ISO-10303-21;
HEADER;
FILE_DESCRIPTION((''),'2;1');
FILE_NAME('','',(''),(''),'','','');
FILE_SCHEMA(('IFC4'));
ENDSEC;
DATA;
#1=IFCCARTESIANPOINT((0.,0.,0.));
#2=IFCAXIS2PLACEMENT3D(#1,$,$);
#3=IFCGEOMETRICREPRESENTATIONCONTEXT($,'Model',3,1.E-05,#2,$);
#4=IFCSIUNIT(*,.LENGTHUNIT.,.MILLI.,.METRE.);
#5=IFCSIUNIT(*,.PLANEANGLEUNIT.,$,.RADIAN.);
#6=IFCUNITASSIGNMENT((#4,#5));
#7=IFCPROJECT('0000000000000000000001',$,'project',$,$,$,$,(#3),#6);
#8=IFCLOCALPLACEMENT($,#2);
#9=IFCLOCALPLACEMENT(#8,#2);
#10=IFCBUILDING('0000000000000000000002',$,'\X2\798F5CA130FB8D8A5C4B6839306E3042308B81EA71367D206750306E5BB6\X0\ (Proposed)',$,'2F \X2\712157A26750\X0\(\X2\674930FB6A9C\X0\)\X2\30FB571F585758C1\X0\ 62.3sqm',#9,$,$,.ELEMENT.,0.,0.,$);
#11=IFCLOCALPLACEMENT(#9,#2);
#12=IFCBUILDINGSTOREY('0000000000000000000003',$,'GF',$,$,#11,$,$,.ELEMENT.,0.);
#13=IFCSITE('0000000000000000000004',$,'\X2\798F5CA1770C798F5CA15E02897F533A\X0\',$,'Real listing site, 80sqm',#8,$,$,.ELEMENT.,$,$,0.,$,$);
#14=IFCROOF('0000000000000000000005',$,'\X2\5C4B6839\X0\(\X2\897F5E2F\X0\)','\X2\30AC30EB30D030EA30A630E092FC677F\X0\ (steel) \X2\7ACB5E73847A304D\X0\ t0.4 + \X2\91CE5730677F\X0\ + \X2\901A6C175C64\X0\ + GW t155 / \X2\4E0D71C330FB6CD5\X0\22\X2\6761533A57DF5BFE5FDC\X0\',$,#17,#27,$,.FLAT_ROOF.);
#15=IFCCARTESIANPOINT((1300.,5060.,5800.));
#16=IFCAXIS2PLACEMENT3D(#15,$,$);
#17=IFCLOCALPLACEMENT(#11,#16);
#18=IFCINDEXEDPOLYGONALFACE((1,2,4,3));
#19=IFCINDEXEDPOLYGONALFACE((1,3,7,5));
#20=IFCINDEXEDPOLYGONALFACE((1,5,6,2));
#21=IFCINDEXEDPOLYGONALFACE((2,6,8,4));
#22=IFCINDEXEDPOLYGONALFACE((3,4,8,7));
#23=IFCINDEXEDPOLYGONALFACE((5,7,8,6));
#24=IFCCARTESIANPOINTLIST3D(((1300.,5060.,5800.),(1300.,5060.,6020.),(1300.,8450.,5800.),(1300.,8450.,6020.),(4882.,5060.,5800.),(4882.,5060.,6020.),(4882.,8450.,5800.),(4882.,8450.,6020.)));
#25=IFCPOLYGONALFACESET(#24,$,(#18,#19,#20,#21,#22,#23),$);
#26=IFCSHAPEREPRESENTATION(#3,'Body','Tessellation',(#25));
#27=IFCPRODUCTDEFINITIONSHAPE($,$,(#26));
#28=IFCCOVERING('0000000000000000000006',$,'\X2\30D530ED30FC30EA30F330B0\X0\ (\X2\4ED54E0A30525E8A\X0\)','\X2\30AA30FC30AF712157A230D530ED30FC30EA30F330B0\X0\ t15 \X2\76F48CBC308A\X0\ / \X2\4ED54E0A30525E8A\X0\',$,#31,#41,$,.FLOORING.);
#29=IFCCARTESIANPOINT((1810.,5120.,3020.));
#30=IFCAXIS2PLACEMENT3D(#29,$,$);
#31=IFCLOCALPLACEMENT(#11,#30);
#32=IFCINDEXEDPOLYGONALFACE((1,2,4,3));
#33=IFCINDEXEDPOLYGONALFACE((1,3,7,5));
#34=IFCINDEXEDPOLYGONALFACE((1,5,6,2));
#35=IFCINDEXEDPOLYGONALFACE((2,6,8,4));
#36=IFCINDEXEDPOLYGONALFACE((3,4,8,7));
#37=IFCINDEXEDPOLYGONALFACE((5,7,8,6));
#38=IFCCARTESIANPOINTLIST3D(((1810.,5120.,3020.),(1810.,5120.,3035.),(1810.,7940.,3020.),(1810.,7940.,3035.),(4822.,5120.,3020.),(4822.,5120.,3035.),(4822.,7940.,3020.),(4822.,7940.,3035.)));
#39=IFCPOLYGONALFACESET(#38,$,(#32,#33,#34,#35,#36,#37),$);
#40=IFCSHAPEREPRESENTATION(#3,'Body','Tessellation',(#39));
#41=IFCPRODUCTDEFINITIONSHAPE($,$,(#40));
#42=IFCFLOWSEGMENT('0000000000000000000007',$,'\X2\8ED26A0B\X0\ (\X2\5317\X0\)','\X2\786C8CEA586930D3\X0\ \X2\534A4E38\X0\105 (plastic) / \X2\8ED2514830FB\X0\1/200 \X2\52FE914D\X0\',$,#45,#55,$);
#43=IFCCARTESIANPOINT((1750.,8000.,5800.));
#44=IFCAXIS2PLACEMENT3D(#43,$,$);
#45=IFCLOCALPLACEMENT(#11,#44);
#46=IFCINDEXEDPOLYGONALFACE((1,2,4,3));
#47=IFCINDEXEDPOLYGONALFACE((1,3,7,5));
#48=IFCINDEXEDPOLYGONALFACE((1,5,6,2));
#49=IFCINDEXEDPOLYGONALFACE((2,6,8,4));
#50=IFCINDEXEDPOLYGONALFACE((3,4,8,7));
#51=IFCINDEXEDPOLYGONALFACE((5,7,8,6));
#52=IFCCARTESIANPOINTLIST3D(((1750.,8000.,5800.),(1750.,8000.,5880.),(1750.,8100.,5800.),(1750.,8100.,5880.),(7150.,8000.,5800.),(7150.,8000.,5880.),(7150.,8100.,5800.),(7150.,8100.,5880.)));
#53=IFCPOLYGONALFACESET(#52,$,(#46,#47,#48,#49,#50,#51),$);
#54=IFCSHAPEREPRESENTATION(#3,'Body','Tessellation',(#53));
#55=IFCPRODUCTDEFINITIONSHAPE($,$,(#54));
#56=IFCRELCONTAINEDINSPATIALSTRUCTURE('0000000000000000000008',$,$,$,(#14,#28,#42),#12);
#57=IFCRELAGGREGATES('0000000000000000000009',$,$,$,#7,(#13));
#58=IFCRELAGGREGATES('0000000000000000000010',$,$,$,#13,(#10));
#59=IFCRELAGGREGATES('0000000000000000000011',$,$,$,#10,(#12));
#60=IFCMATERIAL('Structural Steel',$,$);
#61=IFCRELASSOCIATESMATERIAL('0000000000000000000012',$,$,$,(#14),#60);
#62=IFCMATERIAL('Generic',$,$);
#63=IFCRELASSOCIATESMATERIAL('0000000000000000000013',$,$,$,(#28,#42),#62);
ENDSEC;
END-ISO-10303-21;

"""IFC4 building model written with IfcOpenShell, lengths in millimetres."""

from ifc_helpers import new_model, si_unit, frame, frame_2d, origin, place, context, project, spatial, rectangle, extrude, material, element, save


model = new_model("IFC4")

# Units and contexts
model_context = context("Model", 3, precision=1e-05, world=origin())
ifc_project = project(units=[si_unit("LENGTHUNIT", "METRE", prefix="MILLI"), si_unit("PLANEANGLEUNIT", "RADIAN")], contexts=[model_context])

# Site, building, storey
site_placement = place(None, origin())
site = spatial("IfcSite", under=ifc_project, at=site_placement, Name="福岡県福岡市西区", ObjectType="Real listing site, 80sqm", CompositionType="ELEMENT", RefElevation=0.0)
building_placement = place(site_placement, origin())
building = spatial("IfcBuilding", under=site, at=building_placement, Name="福岡・越屋根のある自然素材の家 (Proposed)", ObjectType="2F 無垢材(杉・檜)・土塗壁 62.3sqm", CompositionType="ELEMENT", ElevationOfRefHeight=0.0, ElevationOfTerrain=0.0)
storey_placement = place(building_placement, origin())
storey = spatial("IfcBuildingStorey", under=building, at=storey_placement, Name="GF", CompositionType="ELEMENT", Elevation=0.0)

# Roof
ifc_material_1 = material(Name="Structural Steel")
for number, where, name in (
    (1, (1300.0, 5060.0, 5800.0), "屋根(西帯)"),
):
    element("IfcRoof", number, at=place(storey_placement, frame(where)), inside=storey, material=ifc_material_1, Name=name, Description="ガルバリウム鋼板 (steel) 立平葺き t0.4 + 野地板 + 通気層 + GW t155 / 不燃・法22条区域対応", PredefinedType="FLAT_ROOF", context=model_context, shape_type="SweptSolid", body=[
        extrude(rectangle(XDim=3582.0, YDim=3390.0, at=frame_2d((1791.0, 1695.0))), frame((1300.0, 5060.0, 5800.0)), (0.0, 0.0, 1.0), 220.0),
    ])

# Covering
ifc_material_2 = material(Name="Generic")
covering_placement = place(storey_placement, frame((1810.0, 5120.0, 3020.0)))
element("IfcCovering", 2, at=covering_placement, inside=storey, material=ifc_material_2, Name="フローリング (仕上げ床)", Description="オーク無垢フローリング t15 直貼り / 仕上げ床", PredefinedType="FLOORING", context=model_context, shape_type="SweptSolid", body=[
    extrude(rectangle(XDim=3012.0, YDim=2820.0, at=frame_2d((1506.0, 1410.0))), frame((1810.0, 5120.0, 3020.0)), (0.0, 0.0, 1.0), 15.0),
])

# Flow segment
flow_segment_placement = place(storey_placement, frame((1750.0, 8000.0, 5800.0)))
element("IfcFlowSegment", 3, at=flow_segment_placement, inside=storey, material=ifc_material_2, Name="軒樋 (北)", Description="硬質塩ビ 半丸105 (plastic) / 軒先・1/200 勾配", context=model_context, shape_type="SweptSolid", body=[
    extrude(rectangle(XDim=5400.0, YDim=100.0, at=frame_2d((2700.0, 50.0))), frame((1750.0, 8000.0, 5800.0)), (0.0, 0.0, 1.0), 80.0),
])

save(model, "model.ifc")
